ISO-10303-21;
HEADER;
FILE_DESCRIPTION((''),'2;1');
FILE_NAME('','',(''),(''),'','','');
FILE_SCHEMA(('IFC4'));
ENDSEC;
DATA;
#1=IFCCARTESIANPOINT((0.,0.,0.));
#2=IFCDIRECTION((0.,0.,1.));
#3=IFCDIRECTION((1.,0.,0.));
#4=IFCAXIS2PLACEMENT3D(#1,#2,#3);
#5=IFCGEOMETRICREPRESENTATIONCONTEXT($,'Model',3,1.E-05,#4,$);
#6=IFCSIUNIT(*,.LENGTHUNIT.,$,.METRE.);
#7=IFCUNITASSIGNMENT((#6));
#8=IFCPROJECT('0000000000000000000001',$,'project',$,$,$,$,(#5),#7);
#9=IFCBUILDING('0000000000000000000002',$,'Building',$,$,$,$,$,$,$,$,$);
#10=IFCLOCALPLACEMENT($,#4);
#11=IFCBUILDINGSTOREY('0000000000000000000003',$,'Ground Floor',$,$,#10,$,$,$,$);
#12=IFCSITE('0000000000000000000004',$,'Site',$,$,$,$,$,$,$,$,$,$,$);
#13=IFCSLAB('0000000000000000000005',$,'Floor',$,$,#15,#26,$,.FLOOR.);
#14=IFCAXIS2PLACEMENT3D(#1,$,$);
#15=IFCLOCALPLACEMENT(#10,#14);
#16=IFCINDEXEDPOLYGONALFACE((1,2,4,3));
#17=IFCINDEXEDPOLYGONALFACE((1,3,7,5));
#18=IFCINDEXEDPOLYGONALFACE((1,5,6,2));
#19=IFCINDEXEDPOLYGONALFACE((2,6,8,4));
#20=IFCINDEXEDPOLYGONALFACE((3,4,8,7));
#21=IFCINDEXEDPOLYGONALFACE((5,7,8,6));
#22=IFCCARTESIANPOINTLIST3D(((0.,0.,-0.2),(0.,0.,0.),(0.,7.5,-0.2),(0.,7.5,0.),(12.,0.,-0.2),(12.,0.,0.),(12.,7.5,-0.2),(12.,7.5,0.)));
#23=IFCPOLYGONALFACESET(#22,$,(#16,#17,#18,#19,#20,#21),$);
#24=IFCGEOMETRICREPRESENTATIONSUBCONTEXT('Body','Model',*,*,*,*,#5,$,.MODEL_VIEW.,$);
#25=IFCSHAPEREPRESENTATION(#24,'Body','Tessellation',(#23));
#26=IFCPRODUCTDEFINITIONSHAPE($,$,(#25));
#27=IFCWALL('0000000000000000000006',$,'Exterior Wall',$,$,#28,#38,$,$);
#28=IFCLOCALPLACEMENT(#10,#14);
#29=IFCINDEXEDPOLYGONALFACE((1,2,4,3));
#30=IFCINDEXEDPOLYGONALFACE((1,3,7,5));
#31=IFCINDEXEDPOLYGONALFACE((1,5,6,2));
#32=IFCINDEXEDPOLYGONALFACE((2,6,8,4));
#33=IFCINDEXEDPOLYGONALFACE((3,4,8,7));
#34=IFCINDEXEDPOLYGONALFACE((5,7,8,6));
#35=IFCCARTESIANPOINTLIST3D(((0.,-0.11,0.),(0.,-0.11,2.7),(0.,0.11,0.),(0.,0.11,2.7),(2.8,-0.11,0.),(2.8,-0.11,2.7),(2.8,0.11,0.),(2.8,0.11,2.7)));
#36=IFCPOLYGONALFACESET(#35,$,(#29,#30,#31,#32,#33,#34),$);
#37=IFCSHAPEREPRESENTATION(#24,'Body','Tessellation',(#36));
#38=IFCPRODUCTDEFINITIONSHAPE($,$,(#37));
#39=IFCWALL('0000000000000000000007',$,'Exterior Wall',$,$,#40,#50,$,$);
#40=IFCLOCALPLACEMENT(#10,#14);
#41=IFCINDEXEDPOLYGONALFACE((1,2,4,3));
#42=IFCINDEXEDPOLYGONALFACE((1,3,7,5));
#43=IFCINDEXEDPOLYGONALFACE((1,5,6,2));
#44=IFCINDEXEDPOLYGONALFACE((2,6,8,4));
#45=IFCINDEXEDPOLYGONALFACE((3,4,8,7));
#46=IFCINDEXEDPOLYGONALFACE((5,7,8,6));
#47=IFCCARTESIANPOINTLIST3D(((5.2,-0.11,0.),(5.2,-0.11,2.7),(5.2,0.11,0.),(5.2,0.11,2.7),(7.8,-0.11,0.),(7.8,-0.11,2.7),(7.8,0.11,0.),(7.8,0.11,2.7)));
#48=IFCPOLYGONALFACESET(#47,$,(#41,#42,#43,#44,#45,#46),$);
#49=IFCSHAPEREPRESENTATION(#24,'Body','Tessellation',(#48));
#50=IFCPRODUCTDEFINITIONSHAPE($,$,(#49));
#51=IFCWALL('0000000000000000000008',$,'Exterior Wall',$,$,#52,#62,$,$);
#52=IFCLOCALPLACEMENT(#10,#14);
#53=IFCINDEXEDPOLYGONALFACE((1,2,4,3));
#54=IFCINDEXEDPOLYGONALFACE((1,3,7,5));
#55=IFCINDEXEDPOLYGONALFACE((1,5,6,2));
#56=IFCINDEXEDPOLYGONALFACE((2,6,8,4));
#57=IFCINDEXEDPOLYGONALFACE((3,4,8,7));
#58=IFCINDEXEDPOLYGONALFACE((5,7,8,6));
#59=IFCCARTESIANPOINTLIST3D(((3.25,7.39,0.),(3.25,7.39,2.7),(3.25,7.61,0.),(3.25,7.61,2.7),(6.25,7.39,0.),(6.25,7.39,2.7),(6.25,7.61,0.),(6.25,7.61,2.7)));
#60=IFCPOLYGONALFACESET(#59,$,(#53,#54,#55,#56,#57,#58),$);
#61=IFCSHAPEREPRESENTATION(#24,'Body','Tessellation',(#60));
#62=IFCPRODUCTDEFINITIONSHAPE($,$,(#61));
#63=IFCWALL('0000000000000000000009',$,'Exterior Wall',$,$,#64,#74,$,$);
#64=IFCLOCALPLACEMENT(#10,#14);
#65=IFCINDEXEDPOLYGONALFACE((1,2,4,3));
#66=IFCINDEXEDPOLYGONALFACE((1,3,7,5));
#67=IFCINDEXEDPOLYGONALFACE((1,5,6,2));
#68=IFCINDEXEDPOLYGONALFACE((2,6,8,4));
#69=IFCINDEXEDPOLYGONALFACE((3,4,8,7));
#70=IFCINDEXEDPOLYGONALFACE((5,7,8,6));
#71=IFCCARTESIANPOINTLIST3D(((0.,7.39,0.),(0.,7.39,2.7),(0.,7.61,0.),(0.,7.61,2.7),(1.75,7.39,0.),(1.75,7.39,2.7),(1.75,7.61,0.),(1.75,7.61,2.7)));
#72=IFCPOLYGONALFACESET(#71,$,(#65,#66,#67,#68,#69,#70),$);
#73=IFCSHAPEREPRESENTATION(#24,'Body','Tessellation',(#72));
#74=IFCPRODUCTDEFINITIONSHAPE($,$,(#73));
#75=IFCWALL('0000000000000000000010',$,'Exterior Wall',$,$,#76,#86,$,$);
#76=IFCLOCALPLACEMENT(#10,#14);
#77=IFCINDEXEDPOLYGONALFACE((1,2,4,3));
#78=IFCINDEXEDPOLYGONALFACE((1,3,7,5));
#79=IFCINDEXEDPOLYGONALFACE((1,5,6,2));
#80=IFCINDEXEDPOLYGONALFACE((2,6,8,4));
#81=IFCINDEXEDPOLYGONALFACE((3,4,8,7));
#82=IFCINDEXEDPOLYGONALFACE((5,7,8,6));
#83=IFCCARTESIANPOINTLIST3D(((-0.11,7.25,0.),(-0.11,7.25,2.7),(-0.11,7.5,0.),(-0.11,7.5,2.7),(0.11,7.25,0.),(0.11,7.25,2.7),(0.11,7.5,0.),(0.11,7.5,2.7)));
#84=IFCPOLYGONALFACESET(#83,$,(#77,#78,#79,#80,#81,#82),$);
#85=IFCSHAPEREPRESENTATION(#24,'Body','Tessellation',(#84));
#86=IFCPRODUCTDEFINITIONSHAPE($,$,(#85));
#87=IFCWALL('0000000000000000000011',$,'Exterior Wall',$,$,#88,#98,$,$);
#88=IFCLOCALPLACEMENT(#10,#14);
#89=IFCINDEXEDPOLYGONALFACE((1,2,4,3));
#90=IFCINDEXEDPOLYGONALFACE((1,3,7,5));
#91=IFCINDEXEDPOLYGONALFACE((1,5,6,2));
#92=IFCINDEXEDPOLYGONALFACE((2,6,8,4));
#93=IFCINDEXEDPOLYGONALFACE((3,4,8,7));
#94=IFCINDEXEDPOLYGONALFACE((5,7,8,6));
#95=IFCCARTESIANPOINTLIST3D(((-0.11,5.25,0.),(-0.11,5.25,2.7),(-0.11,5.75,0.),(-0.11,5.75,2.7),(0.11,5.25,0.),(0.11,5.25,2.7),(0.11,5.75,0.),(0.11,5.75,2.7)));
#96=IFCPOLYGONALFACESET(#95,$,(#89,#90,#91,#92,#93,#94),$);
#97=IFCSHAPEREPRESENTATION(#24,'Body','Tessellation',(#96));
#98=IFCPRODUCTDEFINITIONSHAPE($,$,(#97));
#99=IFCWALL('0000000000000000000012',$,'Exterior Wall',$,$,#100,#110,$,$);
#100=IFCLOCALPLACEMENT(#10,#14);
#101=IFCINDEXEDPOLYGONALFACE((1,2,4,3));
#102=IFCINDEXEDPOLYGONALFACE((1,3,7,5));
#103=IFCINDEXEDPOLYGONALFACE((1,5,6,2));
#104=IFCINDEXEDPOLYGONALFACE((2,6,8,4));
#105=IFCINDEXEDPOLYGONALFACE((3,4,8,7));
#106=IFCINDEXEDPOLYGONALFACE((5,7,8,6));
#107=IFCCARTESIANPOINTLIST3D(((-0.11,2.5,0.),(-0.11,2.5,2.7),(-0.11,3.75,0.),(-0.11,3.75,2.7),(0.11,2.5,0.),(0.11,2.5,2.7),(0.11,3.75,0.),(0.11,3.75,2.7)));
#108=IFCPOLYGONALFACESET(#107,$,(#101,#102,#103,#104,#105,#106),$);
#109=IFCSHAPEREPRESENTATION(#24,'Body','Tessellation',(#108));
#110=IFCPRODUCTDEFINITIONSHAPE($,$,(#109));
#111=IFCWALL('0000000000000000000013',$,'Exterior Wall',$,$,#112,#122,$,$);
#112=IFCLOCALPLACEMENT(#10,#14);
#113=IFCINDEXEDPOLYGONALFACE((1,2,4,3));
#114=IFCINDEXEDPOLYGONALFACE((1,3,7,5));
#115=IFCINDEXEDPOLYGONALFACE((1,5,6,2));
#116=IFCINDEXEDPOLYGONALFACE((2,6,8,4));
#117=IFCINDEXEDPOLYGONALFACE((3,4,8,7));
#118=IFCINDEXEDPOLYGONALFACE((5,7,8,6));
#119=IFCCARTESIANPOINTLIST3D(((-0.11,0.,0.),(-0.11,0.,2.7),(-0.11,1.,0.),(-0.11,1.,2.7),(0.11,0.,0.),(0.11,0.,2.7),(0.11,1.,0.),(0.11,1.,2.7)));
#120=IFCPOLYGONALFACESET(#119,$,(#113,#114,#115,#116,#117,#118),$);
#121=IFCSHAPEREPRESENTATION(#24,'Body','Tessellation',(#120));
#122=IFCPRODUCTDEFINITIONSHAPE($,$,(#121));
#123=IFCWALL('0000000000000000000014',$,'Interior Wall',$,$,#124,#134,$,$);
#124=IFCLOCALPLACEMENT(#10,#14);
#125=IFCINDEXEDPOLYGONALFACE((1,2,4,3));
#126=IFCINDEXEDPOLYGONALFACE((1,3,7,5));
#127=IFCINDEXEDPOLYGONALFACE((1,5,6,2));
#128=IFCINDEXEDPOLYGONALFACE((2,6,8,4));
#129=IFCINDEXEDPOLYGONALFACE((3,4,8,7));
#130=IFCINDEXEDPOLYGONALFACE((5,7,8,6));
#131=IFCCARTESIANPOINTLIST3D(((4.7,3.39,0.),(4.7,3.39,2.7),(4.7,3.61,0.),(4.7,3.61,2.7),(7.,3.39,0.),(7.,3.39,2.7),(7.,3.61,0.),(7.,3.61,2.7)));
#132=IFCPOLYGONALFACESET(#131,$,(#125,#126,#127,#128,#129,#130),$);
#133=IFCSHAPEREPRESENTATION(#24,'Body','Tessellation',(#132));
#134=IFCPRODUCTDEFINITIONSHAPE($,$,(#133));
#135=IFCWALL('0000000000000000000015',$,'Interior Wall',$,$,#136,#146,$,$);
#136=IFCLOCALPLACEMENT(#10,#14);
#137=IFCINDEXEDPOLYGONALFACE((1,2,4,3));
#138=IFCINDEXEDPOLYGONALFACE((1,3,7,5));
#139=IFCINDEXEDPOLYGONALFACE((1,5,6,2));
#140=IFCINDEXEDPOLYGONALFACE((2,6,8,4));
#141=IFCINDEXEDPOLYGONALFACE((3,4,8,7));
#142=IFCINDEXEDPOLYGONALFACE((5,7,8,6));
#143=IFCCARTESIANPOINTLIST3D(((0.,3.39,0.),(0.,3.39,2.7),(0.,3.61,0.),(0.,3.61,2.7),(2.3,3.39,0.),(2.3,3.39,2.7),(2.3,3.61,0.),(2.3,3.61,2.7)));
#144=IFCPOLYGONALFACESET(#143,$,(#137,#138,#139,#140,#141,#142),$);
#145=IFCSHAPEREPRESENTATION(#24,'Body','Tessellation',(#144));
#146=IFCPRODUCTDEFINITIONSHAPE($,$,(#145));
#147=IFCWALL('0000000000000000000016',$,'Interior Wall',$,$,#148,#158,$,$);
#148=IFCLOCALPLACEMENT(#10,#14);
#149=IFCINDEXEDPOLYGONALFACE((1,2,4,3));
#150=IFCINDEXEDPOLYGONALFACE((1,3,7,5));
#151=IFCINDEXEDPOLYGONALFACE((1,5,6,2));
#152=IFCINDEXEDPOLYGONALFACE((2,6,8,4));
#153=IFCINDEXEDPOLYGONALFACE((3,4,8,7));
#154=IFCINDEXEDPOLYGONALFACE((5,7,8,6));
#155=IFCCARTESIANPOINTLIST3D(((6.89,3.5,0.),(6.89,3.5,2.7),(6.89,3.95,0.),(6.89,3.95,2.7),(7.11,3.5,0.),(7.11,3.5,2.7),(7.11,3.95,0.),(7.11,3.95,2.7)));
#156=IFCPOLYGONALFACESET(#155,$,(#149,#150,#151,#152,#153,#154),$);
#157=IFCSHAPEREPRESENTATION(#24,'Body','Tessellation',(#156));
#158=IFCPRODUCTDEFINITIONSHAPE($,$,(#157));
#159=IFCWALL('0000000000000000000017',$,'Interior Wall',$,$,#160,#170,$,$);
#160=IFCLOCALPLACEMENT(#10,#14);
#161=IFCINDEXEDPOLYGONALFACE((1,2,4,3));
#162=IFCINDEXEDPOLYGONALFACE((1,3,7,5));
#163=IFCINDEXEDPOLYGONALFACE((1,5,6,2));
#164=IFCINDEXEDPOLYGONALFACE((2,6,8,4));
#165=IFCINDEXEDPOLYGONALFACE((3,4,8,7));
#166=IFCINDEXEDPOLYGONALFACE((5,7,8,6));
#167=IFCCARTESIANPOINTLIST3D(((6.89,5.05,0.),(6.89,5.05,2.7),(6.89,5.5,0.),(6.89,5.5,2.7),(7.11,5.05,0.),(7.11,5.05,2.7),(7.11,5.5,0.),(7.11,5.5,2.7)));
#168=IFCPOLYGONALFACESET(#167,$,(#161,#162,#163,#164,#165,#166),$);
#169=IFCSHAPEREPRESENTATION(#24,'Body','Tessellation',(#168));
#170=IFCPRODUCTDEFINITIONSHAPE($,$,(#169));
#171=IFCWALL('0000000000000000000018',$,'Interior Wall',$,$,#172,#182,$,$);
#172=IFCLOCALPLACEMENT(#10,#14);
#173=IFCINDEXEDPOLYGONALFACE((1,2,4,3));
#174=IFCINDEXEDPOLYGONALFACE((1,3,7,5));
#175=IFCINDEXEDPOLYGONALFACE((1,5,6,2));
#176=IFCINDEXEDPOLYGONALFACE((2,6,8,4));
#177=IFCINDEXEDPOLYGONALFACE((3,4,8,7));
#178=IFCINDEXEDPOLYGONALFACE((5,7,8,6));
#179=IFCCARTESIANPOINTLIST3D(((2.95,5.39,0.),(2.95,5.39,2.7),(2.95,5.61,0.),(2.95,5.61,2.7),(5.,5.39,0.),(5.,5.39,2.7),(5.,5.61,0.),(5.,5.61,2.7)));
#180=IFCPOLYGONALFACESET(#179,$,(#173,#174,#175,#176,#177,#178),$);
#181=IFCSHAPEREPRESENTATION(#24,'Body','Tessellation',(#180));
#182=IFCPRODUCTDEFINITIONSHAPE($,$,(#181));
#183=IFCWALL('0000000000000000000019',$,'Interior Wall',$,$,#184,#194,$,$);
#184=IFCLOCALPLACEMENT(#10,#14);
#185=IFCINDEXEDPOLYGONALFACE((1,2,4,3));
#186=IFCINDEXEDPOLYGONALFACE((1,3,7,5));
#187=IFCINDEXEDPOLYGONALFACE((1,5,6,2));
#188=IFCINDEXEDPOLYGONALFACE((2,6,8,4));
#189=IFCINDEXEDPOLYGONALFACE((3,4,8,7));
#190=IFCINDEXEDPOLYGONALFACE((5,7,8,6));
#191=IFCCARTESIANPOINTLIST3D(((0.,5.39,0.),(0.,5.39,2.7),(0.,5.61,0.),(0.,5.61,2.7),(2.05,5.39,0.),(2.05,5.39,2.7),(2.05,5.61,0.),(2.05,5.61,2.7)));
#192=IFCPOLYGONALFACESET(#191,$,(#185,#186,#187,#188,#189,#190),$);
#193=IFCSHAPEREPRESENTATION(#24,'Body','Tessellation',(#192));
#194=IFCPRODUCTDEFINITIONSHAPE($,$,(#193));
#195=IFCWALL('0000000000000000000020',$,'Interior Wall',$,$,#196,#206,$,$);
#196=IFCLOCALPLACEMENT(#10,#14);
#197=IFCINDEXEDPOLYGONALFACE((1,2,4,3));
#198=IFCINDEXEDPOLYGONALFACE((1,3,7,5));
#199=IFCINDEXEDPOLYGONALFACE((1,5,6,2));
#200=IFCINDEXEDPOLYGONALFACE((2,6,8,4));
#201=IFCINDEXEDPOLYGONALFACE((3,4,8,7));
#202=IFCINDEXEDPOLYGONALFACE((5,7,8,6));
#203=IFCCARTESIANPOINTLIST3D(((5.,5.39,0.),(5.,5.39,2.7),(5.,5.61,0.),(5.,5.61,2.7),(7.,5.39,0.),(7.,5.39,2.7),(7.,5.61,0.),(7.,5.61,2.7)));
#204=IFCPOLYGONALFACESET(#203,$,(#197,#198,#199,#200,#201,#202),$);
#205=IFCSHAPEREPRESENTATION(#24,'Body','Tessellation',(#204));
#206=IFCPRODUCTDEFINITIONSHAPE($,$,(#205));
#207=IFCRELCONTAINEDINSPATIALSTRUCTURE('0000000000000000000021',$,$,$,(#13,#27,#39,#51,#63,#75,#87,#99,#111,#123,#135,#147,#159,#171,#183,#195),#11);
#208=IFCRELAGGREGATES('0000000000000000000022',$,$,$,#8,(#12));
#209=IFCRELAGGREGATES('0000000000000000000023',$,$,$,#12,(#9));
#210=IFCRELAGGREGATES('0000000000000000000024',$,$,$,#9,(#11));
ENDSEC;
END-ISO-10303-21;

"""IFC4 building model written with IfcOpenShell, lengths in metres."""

from ifc_helpers import new_model, si_unit, frame, origin_with_axes, place, context, subcontext, project, spatial, indexed_curve, outline, extrude, element, save


model = new_model("IFC4")

# Units and contexts
model_context = context("Model", 3, precision=1e-05, world=origin_with_axes())
body_context = subcontext(model_context, "Body", "Model", "MODEL_VIEW")
ifc_project = project(units=[si_unit("LENGTHUNIT", "METRE")], contexts=[model_context])

# Site, building, storey
site = spatial("IfcSite", under=ifc_project, Name="Site")
building = spatial("IfcBuilding", under=site, Name="Building")
storey_placement = place(None, origin_with_axes())
storey = spatial("IfcBuildingStorey", under=building, at=storey_placement, Name="Ground Floor")

# Slab
slab_placement = place(storey_placement, frame((0.0, 0.0, -0.2), z_axis=(0.0, 0.0, 1.0), x_axis=(1.0, 0.0, 0.0)))
element("IfcSlab", 1, at=slab_placement, inside=storey, Name="Floor", PredefinedType="FLOOR", context=body_context, shape_type="SweptSolid", body=[
    extrude(outline(indexed_curve([(0.0, 0.0), (12.0, 0.0), (12.0, 7.5), (0.0, 7.5)])), None, (0.0, 0.0, 1.0), 0.2),
])

# Walls
wall_1_placement = place(storey_placement, origin_with_axes())
element("IfcWall", 2, at=wall_1_placement, inside=storey, Name="Exterior Wall", context=body_context, shape_type="SweptSolid", body=[
    extrude(outline(indexed_curve([(0.0, 0.0), (0.0, 0.22), (2.8, 0.22), (2.8, 0.0), (0.0, 0.0)], self_intersect=False)), frame((0.0, -0.11, 0.0), z_axis=(0.0, 0.0, 1.0), x_axis=(1.0, 0.0, 0.0)), (0.0, 0.0, 1.0), 2.7),
])
wall_2_placement = place(storey_placement, frame((5.2, 0.0, 0.0), z_axis=(0.0, 0.0, 1.0), x_axis=(1.0, 0.0, 0.0)))
element("IfcWall", 3, at=wall_2_placement, inside=storey, Name="Exterior Wall", context=body_context, shape_type="SweptSolid", body=[
    extrude(outline(indexed_curve([(0.0, 0.0), (0.0, 0.22), (2.6, 0.22), (2.6, 0.0), (0.0, 0.0)], self_intersect=False)), frame((0.0, -0.11, 0.0), z_axis=(0.0, 0.0, 1.0), x_axis=(1.0, 0.0, 0.0)), (0.0, 0.0, 1.0), 2.7),
])
wall_3_placement = place(storey_placement, frame((6.25, 7.5, 0.0), z_axis=(0.0, 0.0, 1.0), x_axis=(-1.0, 0.0, 0.0)))
element("IfcWall", 4, at=wall_3_placement, inside=storey, Name="Exterior Wall", context=body_context, shape_type="SweptSolid", body=[
    extrude(outline(indexed_curve([(0.0, 0.0), (0.0, 0.22), (3.0, 0.22), (3.0, 0.0), (0.0, 0.0)], self_intersect=False)), frame((0.0, -0.11, 0.0), z_axis=(0.0, 0.0, 1.0), x_axis=(1.0, 0.0, 0.0)), (0.0, 0.0, 1.0), 2.7),
])
wall_4_placement = place(storey_placement, frame((1.75, 7.5, 0.0), z_axis=(0.0, 0.0, 1.0), x_axis=(-1.0, 0.0, 0.0)))
element("IfcWall", 5, at=wall_4_placement, inside=storey, Name="Exterior Wall", context=body_context, shape_type="SweptSolid", body=[
    extrude(outline(indexed_curve([(0.0, 0.0), (0.0, 0.22), (1.75, 0.22), (1.75, 0.0), (0.0, 0.0)], self_intersect=False)), frame((0.0, -0.11, 0.0), z_axis=(0.0, 0.0, 1.0), x_axis=(1.0, 0.0, 0.0)), (0.0, 0.0, 1.0), 2.7),
])
wall_5_placement = place(storey_placement, frame((0.0, 7.5, 0.0), z_axis=(0.0, 0.0, 1.0), x_axis=(0.0, -1.0, 0.0)))
element("IfcWall", 6, at=wall_5_placement, inside=storey, Name="Exterior Wall", context=body_context, shape_type="SweptSolid", body=[
    extrude(outline(indexed_curve([(0.0, 0.0), (0.0, 0.22), (0.25, 0.22), (0.25, 0.0), (0.0, 0.0)], self_intersect=False)), frame((0.0, -0.11, 0.0), z_axis=(0.0, 0.0, 1.0), x_axis=(1.0, 0.0, 0.0)), (0.0, 0.0, 1.0), 2.7),
])
wall_6_placement = place(storey_placement, frame((0.0, 5.75, 0.0), z_axis=(0.0, 0.0, 1.0), x_axis=(0.0, -1.0, 0.0)))
element("IfcWall", 7, at=wall_6_placement, inside=storey, Name="Exterior Wall", context=body_context, shape_type="SweptSolid", body=[
    extrude(outline(indexed_curve([(0.0, 0.0), (0.0, 0.22), (0.5, 0.22), (0.5, 0.0), (0.0, 0.0)], self_intersect=False)), frame((0.0, -0.11, 0.0), z_axis=(0.0, 0.0, 1.0), x_axis=(1.0, 0.0, 0.0)), (0.0, 0.0, 1.0), 2.7),
])
wall_7_placement = place(storey_placement, frame((0.0, 3.75, 0.0), z_axis=(0.0, 0.0, 1.0), x_axis=(0.0, -1.0, 0.0)))
element("IfcWall", 8, at=wall_7_placement, inside=storey, Name="Exterior Wall", context=body_context, shape_type="SweptSolid", body=[
    extrude(outline(indexed_curve([(0.0, 0.0), (0.0, 0.22), (1.25, 0.22), (1.25, 0.0), (0.0, 0.0)], self_intersect=False)), frame((0.0, -0.11, 0.0), z_axis=(0.0, 0.0, 1.0), x_axis=(1.0, 0.0, 0.0)), (0.0, 0.0, 1.0), 2.7),
])
wall_8_placement = place(storey_placement, frame((0.0, 1.0, 0.0), z_axis=(0.0, 0.0, 1.0), x_axis=(0.0, -1.0, 0.0)))
element("IfcWall", 9, at=wall_8_placement, inside=storey, Name="Exterior Wall", context=body_context, shape_type="SweptSolid", body=[
    extrude(outline(indexed_curve([(0.0, 0.0), (0.0, 0.22), (1.0, 0.22), (1.0, 0.0), (0.0, 0.0)], self_intersect=False)), frame((0.0, -0.11, 0.0), z_axis=(0.0, 0.0, 1.0), x_axis=(1.0, 0.0, 0.0)), (0.0, 0.0, 1.0), 2.7),
])
for number, where, z_axis, x_axis, name in (
    (10, (7.0, 3.5, 0.0), (0.0, 0.0, 1.0), (-1.0, 0.0, 0.0), "Interior Wall"),
    (11, (2.3, 3.5, 0.0), (0.0, 0.0, 1.0), (-1.0, 0.0, 0.0), "Interior Wall"),
):
    element("IfcWall", number, at=place(storey_placement, frame(where, z_axis=z_axis, x_axis=x_axis)), inside=storey, Name=name, context=body_context, shape_type="SweptSolid", body=[
        extrude(outline(indexed_curve([(0.0, 0.0), (0.0, 0.22), (2.3, 0.22), (2.3, 0.0), (0.0, 0.0)], self_intersect=False)), frame((0.0, -0.11, 0.0), z_axis=(0.0, 0.0, 1.0), x_axis=(1.0, 0.0, 0.0)), (0.0, 0.0, 1.0), 2.7),
    ])
for number, where, z_axis, x_axis, name in (
    (12, (7.0, 3.5, 0.0), (0.0, 0.0, 1.0), (0.0, 1.0, 0.0), "Interior Wall"),
    (13, (7.0, 5.05, 0.0), (0.0, 0.0, 1.0), (0.0, 1.0, 0.0), "Interior Wall"),
):
    element("IfcWall", number, at=place(storey_placement, frame(where, z_axis=z_axis, x_axis=x_axis)), inside=storey, Name=name, context=body_context, shape_type="SweptSolid", body=[
        extrude(outline(indexed_curve([(0.0, 0.0), (0.0, 0.22), (0.45, 0.22), (0.45, 0.0), (0.0, 0.0)], self_intersect=False)), frame((0.0, -0.11, 0.0), z_axis=(0.0, 0.0, 1.0), x_axis=(1.0, 0.0, 0.0)), (0.0, 0.0, 1.0), 2.7),
    ])
for number, where, z_axis, x_axis, name in (
    (14, (5.0, 5.5, 0.0), (0.0, 0.0, 1.0), (-1.0, 0.0, 0.0), "Interior Wall"),
    (15, (2.05, 5.5, 0.0), (0.0, 0.0, 1.0), (-1.0, 0.0, 0.0), "Interior Wall"),
):
    element("IfcWall", number, at=place(storey_placement, frame(where, z_axis=z_axis, x_axis=x_axis)), inside=storey, Name=name, context=body_context, shape_type="SweptSolid", body=[
        extrude(outline(indexed_curve([(0.0, 0.0), (0.0, 0.22), (2.05, 0.22), (2.05, 0.0), (0.0, 0.0)], self_intersect=False)), frame((0.0, -0.11, 0.0), z_axis=(0.0, 0.0, 1.0), x_axis=(1.0, 0.0, 0.0)), (0.0, 0.0, 1.0), 2.7),
    ])
for number, where, z_axis, x_axis, name in (
    (16, (7.0, 5.5, 0.0), (0.0, 0.0, 1.0), (-1.0, 0.0, 0.0), "Interior Wall"),
):
    element("IfcWall", number, at=place(storey_placement, frame(where, z_axis=z_axis, x_axis=x_axis)), inside=storey, Name=name, context=body_context, shape_type="SweptSolid", body=[
        extrude(outline(indexed_curve([(0.0, 0.0), (0.0, 0.22), (2.0, 0.22), (2.0, 0.0), (0.0, 0.0)], self_intersect=False)), frame((0.0, -0.11, 0.0), z_axis=(0.0, 0.0, 1.0), x_axis=(1.0, 0.0, 0.0)), (0.0, 0.0, 1.0), 2.7),
    ])

save(model, "model.ifc")
